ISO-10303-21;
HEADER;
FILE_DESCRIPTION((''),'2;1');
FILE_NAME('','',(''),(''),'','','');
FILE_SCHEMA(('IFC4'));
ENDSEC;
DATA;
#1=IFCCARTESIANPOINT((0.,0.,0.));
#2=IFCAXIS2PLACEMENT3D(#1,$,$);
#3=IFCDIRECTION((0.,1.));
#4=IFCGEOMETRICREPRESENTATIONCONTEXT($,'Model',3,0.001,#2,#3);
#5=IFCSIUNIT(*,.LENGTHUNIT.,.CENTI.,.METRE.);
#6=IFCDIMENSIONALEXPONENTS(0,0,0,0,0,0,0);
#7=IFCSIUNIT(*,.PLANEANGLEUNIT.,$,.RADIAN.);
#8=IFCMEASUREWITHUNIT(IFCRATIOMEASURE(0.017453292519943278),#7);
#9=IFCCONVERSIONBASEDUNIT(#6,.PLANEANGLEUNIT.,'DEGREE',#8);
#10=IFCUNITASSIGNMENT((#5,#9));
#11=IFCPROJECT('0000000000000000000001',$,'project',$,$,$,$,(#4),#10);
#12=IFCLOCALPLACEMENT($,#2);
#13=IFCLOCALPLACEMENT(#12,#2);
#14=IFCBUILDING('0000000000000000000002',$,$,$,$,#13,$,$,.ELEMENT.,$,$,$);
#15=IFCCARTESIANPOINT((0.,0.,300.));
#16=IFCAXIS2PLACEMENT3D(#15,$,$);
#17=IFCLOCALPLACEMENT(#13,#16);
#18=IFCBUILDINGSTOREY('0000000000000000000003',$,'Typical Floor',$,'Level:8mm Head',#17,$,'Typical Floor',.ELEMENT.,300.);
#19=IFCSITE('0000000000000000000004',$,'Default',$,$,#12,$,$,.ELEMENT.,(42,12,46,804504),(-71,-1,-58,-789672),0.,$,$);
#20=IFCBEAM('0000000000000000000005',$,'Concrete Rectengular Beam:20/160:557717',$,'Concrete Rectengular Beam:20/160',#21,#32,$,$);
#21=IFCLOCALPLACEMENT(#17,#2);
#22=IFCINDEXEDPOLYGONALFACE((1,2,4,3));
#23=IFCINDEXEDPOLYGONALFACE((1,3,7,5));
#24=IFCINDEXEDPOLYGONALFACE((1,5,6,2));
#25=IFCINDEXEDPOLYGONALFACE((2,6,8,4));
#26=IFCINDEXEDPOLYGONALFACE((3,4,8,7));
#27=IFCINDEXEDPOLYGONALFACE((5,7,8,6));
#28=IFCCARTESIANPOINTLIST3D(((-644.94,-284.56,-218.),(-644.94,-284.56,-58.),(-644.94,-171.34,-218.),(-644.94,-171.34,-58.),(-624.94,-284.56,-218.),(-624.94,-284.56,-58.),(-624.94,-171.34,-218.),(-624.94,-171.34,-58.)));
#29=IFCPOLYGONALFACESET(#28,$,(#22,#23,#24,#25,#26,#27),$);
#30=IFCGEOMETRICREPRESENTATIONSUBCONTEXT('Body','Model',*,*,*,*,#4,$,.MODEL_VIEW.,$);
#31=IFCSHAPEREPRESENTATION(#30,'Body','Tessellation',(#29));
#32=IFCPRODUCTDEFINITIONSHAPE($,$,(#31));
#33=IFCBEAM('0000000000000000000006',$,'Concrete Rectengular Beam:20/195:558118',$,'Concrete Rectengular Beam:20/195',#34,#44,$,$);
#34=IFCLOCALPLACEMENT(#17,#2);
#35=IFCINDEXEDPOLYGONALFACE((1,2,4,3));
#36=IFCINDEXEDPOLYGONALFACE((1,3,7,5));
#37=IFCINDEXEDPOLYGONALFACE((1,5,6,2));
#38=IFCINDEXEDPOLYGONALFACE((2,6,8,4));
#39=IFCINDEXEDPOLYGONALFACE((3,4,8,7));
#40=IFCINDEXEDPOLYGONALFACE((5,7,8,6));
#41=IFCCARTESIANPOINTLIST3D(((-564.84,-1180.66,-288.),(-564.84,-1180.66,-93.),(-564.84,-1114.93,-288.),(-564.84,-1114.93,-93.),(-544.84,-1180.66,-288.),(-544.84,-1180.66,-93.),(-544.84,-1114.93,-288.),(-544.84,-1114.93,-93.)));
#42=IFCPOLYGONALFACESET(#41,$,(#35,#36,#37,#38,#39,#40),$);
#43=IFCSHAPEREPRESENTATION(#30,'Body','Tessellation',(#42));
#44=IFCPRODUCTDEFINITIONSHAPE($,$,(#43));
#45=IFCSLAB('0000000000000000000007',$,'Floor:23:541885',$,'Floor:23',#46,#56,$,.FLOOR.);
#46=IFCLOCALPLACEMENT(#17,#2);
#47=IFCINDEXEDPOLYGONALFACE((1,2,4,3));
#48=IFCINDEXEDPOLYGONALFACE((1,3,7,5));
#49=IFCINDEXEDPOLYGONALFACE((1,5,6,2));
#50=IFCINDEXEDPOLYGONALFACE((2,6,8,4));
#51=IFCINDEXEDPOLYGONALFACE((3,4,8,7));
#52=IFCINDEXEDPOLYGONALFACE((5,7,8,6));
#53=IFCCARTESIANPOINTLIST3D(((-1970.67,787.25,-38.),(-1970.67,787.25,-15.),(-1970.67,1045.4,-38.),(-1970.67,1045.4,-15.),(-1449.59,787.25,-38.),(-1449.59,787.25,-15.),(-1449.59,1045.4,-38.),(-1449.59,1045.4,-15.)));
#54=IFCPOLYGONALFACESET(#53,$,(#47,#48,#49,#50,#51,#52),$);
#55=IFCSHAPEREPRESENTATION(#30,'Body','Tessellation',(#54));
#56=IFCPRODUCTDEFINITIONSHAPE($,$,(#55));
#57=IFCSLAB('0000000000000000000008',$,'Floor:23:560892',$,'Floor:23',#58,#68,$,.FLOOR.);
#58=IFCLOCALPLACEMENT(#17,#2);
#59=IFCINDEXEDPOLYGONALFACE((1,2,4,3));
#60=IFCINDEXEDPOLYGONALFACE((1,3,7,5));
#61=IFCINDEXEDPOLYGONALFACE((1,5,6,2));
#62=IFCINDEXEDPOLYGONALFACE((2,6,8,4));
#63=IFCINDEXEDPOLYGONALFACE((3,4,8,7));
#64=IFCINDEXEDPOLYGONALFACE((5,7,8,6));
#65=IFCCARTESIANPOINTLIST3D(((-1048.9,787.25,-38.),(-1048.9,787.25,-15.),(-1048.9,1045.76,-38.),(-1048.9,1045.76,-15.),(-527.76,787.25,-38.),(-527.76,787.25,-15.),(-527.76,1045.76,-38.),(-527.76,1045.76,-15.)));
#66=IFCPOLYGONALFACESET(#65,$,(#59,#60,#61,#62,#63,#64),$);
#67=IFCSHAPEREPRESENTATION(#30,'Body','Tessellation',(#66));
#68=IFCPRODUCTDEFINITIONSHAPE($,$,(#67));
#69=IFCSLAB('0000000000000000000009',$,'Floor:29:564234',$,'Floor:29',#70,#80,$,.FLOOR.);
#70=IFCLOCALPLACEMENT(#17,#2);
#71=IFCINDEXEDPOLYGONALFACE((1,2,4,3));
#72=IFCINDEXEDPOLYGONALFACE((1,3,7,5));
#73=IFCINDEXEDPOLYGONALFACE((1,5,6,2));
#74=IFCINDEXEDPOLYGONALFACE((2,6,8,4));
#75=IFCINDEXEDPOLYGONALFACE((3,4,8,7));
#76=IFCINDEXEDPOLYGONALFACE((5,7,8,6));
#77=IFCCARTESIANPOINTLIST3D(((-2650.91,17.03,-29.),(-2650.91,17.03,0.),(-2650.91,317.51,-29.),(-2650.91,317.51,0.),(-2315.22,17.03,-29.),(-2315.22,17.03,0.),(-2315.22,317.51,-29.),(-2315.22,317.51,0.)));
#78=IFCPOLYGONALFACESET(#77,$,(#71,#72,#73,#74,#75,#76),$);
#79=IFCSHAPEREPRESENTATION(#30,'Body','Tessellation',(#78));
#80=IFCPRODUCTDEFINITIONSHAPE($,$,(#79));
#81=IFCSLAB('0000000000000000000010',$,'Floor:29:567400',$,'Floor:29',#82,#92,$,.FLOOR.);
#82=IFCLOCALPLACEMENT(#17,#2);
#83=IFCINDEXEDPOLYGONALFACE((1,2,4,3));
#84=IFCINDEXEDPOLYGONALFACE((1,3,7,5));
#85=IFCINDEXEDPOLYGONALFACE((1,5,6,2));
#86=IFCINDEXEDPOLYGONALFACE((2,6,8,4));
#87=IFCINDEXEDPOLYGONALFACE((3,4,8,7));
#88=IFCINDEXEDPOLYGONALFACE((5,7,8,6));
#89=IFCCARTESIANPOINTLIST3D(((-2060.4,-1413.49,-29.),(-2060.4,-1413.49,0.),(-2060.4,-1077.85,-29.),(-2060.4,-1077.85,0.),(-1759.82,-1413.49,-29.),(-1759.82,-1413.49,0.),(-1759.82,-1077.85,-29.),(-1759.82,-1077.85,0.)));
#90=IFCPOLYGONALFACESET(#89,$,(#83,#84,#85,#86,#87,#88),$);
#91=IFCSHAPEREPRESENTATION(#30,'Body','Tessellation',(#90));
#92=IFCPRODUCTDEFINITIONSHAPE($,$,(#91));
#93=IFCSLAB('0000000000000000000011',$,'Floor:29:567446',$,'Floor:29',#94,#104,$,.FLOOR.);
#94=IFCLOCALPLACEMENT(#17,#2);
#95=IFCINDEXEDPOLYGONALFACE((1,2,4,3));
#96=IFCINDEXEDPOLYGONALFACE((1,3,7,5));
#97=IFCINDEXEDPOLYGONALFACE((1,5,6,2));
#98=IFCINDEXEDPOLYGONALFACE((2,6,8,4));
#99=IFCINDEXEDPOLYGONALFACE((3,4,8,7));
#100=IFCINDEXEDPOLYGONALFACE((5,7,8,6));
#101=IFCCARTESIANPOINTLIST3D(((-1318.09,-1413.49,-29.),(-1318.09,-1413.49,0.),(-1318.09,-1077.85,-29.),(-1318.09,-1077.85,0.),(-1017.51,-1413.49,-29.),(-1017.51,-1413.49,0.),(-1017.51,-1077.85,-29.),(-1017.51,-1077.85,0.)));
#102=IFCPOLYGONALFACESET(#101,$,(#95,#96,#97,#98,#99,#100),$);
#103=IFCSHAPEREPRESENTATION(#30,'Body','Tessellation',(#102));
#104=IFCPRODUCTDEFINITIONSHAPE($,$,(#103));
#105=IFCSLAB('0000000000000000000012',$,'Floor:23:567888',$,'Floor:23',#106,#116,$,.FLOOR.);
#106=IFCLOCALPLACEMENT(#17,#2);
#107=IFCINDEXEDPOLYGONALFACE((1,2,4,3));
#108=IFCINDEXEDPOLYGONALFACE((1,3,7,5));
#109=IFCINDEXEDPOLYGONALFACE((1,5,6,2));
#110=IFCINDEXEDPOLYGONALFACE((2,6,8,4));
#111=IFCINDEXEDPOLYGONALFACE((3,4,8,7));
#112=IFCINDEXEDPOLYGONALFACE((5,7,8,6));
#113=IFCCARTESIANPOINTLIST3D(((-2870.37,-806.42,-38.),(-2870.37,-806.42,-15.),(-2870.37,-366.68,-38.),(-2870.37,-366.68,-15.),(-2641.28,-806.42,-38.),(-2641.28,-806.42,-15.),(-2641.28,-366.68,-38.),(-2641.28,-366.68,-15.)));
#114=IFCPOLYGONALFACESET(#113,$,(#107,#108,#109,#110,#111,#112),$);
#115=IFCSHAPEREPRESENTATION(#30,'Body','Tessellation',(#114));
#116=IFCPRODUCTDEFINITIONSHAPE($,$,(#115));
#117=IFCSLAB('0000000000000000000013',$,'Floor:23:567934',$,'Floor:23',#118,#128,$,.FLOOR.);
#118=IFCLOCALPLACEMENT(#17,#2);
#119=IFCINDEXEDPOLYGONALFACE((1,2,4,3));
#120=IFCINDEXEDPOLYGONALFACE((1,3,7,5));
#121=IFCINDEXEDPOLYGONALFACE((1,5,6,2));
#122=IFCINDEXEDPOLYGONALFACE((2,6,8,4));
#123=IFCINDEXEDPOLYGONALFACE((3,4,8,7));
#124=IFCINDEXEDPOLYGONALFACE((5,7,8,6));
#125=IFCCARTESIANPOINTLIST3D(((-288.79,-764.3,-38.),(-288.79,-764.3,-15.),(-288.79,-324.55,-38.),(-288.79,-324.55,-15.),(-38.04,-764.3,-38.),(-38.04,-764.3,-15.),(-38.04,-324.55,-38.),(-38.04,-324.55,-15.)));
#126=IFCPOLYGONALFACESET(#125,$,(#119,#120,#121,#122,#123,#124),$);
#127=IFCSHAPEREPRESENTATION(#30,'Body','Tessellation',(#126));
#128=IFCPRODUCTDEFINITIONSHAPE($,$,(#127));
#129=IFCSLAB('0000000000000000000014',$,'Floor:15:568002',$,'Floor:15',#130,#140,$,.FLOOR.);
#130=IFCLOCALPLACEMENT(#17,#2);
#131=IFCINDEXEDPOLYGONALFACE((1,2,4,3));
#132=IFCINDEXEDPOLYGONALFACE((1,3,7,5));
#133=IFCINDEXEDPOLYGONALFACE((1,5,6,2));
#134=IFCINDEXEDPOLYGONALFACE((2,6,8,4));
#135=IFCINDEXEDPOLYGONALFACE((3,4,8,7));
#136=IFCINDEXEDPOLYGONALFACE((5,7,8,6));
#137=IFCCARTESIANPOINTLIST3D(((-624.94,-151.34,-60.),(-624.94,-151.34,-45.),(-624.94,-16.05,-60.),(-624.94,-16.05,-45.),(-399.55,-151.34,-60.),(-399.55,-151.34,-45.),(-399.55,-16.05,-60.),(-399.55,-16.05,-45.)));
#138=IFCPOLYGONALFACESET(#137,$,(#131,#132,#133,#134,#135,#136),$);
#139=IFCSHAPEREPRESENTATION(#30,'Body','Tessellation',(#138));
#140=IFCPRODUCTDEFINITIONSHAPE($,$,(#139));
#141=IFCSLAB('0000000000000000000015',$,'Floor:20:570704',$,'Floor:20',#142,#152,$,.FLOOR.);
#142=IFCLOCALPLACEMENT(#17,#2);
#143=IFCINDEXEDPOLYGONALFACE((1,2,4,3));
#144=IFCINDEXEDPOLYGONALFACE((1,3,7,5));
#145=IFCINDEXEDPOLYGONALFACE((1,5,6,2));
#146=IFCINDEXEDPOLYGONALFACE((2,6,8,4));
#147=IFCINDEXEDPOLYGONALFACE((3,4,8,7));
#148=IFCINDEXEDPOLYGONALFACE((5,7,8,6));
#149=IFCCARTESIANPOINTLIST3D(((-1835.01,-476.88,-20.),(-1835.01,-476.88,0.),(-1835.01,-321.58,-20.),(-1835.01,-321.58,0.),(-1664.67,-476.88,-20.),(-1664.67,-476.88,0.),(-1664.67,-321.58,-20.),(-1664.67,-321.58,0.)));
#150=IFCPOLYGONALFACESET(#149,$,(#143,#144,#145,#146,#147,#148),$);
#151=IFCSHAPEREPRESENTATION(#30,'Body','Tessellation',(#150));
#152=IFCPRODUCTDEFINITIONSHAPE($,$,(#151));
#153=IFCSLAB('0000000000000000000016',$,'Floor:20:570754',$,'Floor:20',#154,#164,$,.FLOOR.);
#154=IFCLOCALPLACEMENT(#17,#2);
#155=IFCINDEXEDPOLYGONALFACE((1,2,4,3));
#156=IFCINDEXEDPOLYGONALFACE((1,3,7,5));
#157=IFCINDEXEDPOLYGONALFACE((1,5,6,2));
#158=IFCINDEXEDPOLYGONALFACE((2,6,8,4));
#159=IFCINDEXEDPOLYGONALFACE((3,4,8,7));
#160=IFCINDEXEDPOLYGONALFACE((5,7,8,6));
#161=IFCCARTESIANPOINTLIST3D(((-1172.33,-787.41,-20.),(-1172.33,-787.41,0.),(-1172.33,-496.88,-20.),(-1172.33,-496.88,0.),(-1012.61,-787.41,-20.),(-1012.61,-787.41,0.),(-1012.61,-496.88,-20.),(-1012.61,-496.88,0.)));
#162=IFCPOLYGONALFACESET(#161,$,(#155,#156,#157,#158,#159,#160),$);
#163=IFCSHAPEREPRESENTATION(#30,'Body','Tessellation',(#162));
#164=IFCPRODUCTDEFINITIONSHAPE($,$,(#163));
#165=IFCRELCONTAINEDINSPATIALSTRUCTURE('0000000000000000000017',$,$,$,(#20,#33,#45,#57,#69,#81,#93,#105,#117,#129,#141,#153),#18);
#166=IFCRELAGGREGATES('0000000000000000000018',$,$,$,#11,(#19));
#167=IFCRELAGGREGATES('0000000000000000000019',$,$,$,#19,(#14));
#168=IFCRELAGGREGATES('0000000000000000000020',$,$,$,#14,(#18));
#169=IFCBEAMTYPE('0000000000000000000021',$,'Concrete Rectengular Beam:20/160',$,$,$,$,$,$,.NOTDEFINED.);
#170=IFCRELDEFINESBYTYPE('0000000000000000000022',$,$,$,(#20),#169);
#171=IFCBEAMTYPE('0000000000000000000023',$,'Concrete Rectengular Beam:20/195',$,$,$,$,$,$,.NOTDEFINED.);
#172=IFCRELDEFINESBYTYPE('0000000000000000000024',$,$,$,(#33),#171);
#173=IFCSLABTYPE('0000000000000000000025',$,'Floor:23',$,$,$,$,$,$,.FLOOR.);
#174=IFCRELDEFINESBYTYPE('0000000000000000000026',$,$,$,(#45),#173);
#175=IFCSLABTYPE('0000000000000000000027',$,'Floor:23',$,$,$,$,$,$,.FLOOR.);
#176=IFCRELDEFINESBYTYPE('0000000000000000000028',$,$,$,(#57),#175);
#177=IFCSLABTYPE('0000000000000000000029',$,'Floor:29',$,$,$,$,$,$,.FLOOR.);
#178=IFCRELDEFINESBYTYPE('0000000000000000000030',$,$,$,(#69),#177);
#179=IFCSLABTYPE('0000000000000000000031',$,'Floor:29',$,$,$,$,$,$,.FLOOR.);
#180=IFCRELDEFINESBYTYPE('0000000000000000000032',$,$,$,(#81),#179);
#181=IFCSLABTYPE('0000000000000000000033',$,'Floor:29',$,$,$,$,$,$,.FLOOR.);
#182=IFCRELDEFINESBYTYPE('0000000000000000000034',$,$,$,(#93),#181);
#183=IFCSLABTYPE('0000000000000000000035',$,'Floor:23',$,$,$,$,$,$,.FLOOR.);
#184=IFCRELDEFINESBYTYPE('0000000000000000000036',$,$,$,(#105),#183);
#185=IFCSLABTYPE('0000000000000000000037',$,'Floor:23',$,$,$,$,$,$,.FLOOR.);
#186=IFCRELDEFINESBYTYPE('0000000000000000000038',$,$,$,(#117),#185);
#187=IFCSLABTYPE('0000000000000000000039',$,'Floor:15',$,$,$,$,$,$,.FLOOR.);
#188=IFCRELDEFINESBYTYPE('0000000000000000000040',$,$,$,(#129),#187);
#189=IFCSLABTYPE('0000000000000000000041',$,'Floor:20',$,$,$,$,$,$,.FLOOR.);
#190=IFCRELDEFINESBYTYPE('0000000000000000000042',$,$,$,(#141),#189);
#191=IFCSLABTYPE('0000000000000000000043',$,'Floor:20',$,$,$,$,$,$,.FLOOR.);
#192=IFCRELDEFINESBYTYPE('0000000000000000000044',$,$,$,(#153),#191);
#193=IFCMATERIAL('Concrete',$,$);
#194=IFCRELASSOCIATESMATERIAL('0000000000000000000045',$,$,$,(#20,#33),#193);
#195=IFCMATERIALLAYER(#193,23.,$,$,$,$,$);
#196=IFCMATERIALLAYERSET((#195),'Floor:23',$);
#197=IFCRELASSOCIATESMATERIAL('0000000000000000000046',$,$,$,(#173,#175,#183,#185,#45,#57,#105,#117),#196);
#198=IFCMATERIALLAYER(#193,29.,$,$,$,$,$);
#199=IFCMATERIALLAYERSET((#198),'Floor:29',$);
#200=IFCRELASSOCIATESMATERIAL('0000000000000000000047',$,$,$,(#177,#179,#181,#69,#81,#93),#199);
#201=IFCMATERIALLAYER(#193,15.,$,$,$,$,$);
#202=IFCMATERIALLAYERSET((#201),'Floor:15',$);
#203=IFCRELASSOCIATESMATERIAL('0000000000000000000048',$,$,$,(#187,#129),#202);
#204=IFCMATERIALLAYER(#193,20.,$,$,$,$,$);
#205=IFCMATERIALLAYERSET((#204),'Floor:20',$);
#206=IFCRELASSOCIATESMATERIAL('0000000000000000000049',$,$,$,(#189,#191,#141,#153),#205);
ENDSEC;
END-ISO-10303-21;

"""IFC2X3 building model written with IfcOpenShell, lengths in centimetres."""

from ifc_helpers import new_model, entity, si_unit, converted_unit, direction, frame, frame_2d, origin, origin_2d_with_axis, place, context, subcontext, project, spatial, rectangle, extrude, material, layer, layer_set, layer_usage, type_object, element, save


model = new_model("IFC2X3")

# Units and contexts
model_context = context("Model", 3, precision=0.001, world=origin(), true_north=direction((0.0, 1.0)))
body_context = subcontext(model_context, "Body", "Model", "MODEL_VIEW")
ifc_project = project(units=[si_unit("LENGTHUNIT", "METRE", prefix="CENTI"), converted_unit("PLANEANGLEUNIT", "DEGREE", entity("IfcRatioMeasure", 0.017453292519943278), si_unit("PLANEANGLEUNIT", "RADIAN"), dimensions=[0, 0, 0, 0, 0, 0, 0])], contexts=[model_context])

# Site, building, storey
site_placement = place(None, origin())
site = spatial("IfcSite", under=ifc_project, at=site_placement, Name="Default", CompositionType="ELEMENT", RefLatitude=(42, 12, 46, 804504), RefLongitude=(-71, -1, -58, -789672), RefElevation=0.0)
building_placement = place(site_placement, origin())
building = spatial("IfcBuilding", under=site, at=building_placement, CompositionType="ELEMENT")
storey_placement = place(building_placement, frame((0.0, 0.0, 300.0)))
storey = spatial("IfcBuildingStorey", under=building, at=storey_placement, Name="Typical Floor", ObjectType="Level:8mm Head", LongName="Typical Floor", CompositionType="ELEMENT", Elevation=300.0)

# Beams
ifc_material = material(Name="Concrete")
beam_type_1 = type_object("IfcBeamType", Name="Concrete Rectengular Beam:20/160", PredefinedType="NOTDEFINED")
beam_1_placement = place(storey_placement, frame((-634.94, -304.55, 0.0), z_axis=(0.0, 0.0, 1.0), x_axis=(0.0, 1.0, 0.0)))
element("IfcBeam", 1, at=beam_1_placement, inside=storey, type_object=beam_type_1, material=ifc_material, Name="Concrete Rectengular Beam:20/160:557717", ObjectType="Concrete Rectengular Beam:20/160", context=body_context, shape_type="SweptSolid", body=[
    extrude(rectangle(XDim=160.0, YDim=20.0, at=frame_2d((0.0, 0.0), x_axis=(1.0, 0.0))), frame((20.0, 0.0, -138.0), z_axis=(1.0, 0.0, 0.0), x_axis=(0.0, 0.0, -1.0)), (0.0, 0.0, 1.0), 113.22),
])
beam_type_2 = type_object("IfcBeamType", Name="Concrete Rectengular Beam:20/195", PredefinedType="NOTDEFINED")
beam_2_placement = place(storey_placement, frame((-554.84, -1190.66, 0.0), z_axis=(0.0, 0.0, 1.0), x_axis=(0.0, 1.0, 0.0)))
element("IfcBeam", 2, at=beam_2_placement, inside=storey, type_object=beam_type_2, material=ifc_material, Name="Concrete Rectengular Beam:20/195:558118", ObjectType="Concrete Rectengular Beam:20/195", context=body_context, shape_type="SweptSolid", body=[
    extrude(rectangle(XDim=195.0, YDim=20.0, at=frame_2d((0.0, 0.0), x_axis=(1.0, 0.0))), frame((10.0, 0.0, -190.5), z_axis=(1.0, 0.0, 0.0), x_axis=(0.0, 0.0, -1.0)), (0.0, 0.0, 1.0), 65.73),
])

# Slabs
ifc_layer_1 = layer(ifc_material, 23.0)
ifc_layer_set_1 = layer_set([ifc_layer_1], Name="Floor:23")
ifc_layer_usage_1 = layer_usage(ifc_layer_set_1, "AXIS3", "POSITIVE", 0.0)
slab_type_1 = type_object("IfcSlabType", Name="Floor:23", PredefinedType="FLOOR", material=ifc_layer_set_1)
slab_1_placement = place(storey_placement, origin())
element("IfcSlab", 3, at=slab_1_placement, inside=storey, type_object=slab_type_1, material=ifc_layer_usage_1, Name="Floor:23:541885", ObjectType="Floor:23", PredefinedType="FLOOR", context=body_context, shape_type="SweptSolid", body=[
    extrude(rectangle(XDim=258.15, YDim=521.09, at=frame_2d((0.0, 0.0), x_axis=(1.0, 0.0))), frame((-1710.13, 916.32, -15.0), z_axis=(0.0, 0.0, -1.0), x_axis=(0.0, 1.0, 0.0)), (0.0, 0.0, 1.0), 23.0),
])
ifc_layer_usage_2 = layer_usage(ifc_layer_set_1, "AXIS3", "POSITIVE", 0.0)
slab_type_2 = type_object("IfcSlabType", Name="Floor:23", PredefinedType="FLOOR", material=ifc_layer_set_1)
slab_2_placement = place(storey_placement, origin())
element("IfcSlab", 4, at=slab_2_placement, inside=storey, type_object=slab_type_2, material=ifc_layer_usage_2, Name="Floor:23:560892", ObjectType="Floor:23", PredefinedType="FLOOR", context=body_context, shape_type="SweptSolid", body=[
    extrude(rectangle(XDim=258.51, YDim=521.14, at=origin_2d_with_axis()), frame((-788.33, 916.51, -15.0), z_axis=(0.0, 0.0, -1.0), x_axis=(0.0, 1.0, 0.0)), (0.0, 0.0, 1.0), 23.0),
])
ifc_layer_2 = layer(ifc_material, 20.0)
ifc_layer_set_2 = layer_set([ifc_layer_2], Name="Floor:20")
ifc_layer_3 = layer(ifc_material, 29.0)
ifc_layer_set_3 = layer_set([ifc_layer_3], Name="Floor:29")
ifc_layer_usage_3 = layer_usage(ifc_layer_set_3, "AXIS3", "POSITIVE", 0.0)
slab_type_3 = type_object("IfcSlabType", Name="Floor:29", PredefinedType="FLOOR", material=ifc_layer_set_3)
slab_3_placement = place(storey_placement, origin())
element("IfcSlab", 5, at=slab_3_placement, inside=storey, type_object=slab_type_3, material=ifc_layer_usage_3, Name="Floor:29:564234", ObjectType="Floor:29", PredefinedType="FLOOR", context=body_context, shape_type="SweptSolid", body=[
    extrude(rectangle(XDim=300.48, YDim=335.68, at=frame_2d((0.0, 0.0), x_axis=(1.0, 0.0))), frame((-2483.06, 167.27, 0.0), z_axis=(0.0, 0.0, -1.0), x_axis=(0.0, 1.0, 0.0)), (0.0, 0.0, 1.0), 29.0),
])
ifc_layer_usage_4 = layer_usage(ifc_layer_set_3, "AXIS3", "POSITIVE", 0.0)
slab_type_4 = type_object("IfcSlabType", Name="Floor:29", PredefinedType="FLOOR", material=ifc_layer_set_3)
slab_4_placement = place(storey_placement, origin())
element("IfcSlab", 6, at=slab_4_placement, inside=storey, type_object=slab_type_4, material=ifc_layer_usage_4, Name="Floor:29:567400", ObjectType="Floor:29", PredefinedType="FLOOR", context=body_context, shape_type="SweptSolid", body=[
    extrude(rectangle(XDim=335.63, YDim=300.59, at=frame_2d((0.0, 0.0), x_axis=(1.0, 0.0))), frame((-1910.11, -1245.67, 0.0), z_axis=(0.0, 0.0, -1.0), x_axis=(0.0, 1.0, 0.0)), (0.0, 0.0, 1.0), 29.0),
])
ifc_layer_usage_5 = layer_usage(ifc_layer_set_3, "AXIS3", "POSITIVE", 0.0)
slab_type_5 = type_object("IfcSlabType", Name="Floor:29", PredefinedType="FLOOR", material=ifc_layer_set_3)
slab_5_placement = place(storey_placement, origin())
element("IfcSlab", 7, at=slab_5_placement, inside=storey, type_object=slab_type_5, material=ifc_layer_usage_5, Name="Floor:29:567446", ObjectType="Floor:29", PredefinedType="FLOOR", context=body_context, shape_type="SweptSolid", body=[
    extrude(rectangle(XDim=335.63, YDim=300.59, at=frame_2d((0.0, 0.0), x_axis=(1.0, 0.0))), frame((-1167.8, -1245.67, 0.0), z_axis=(0.0, 0.0, -1.0), x_axis=(0.0, 1.0, 0.0)), (0.0, 0.0, 1.0), 29.0),
])
ifc_layer_usage_6 = layer_usage(ifc_layer_set_1, "AXIS3", "POSITIVE", 0.0)
slab_type_6 = type_object("IfcSlabType", Name="Floor:23", PredefinedType="FLOOR", material=ifc_layer_set_1)
slab_6_placement = place(storey_placement, origin())
element("IfcSlab", 8, at=slab_6_placement, inside=storey, type_object=slab_type_6, material=ifc_layer_usage_6, Name="Floor:23:567888", ObjectType="Floor:23", PredefinedType="FLOOR", context=body_context, shape_type="SweptSolid", body=[
    extrude(rectangle(XDim=439.74, YDim=229.09, at=frame_2d((0.0, 0.0), x_axis=(1.0, 0.0))), frame((-2755.82, -586.55, -15.0), z_axis=(0.0, 0.0, -1.0), x_axis=(0.0, 1.0, 0.0)), (0.0, 0.0, 1.0), 23.0),
])
ifc_layer_usage_7 = layer_usage(ifc_layer_set_1, "AXIS3", "POSITIVE", 0.0)
slab_type_7 = type_object("IfcSlabType", Name="Floor:23", PredefinedType="FLOOR", material=ifc_layer_set_1)
slab_7_placement = place(storey_placement, origin())
element("IfcSlab", 9, at=slab_7_placement, inside=storey, type_object=slab_type_7, material=ifc_layer_usage_7, Name="Floor:23:567934", ObjectType="Floor:23", PredefinedType="FLOOR", context=body_context, shape_type="SweptSolid", body=[
    extrude(rectangle(XDim=439.75, YDim=250.76, at=frame_2d((0.0, 0.0), x_axis=(1.0, 0.0))), frame((-163.41, -544.43, -15.0), z_axis=(0.0, 0.0, -1.0), x_axis=(0.0, 1.0, 0.0)), (0.0, 0.0, 1.0), 23.0),
])
ifc_layer_4 = layer(ifc_material, 15.0)
ifc_layer_set_4 = layer_set([ifc_layer_4], Name="Floor:15")
ifc_layer_usage_8 = layer_usage(ifc_layer_set_4, "AXIS3", "POSITIVE", 0.0)
slab_type_8 = type_object("IfcSlabType", Name="Floor:15", PredefinedType="FLOOR", material=ifc_layer_set_4)
slab_8_placement = place(storey_placement, origin())
element("IfcSlab", 10, at=slab_8_placement, inside=storey, type_object=slab_type_8, material=ifc_layer_usage_8, Name="Floor:15:568002", ObjectType="Floor:15", PredefinedType="FLOOR", context=body_context, shape_type="SweptSolid", body=[
    extrude(rectangle(XDim=135.29, YDim=225.39, at=frame_2d((0.0, 0.0), x_axis=(1.0, 0.0))), frame((-512.24, -83.69, -45.0), z_axis=(0.0, 0.0, -1.0), x_axis=(0.0, 1.0, 0.0)), (0.0, 0.0, 1.0), 15.0),
])
ifc_layer_usage_9 = layer_usage(ifc_layer_set_2, "AXIS3", "POSITIVE", 0.0)
slab_type_9 = type_object("IfcSlabType", Name="Floor:20", PredefinedType="FLOOR", material=ifc_layer_set_2)
slab_9_placement = place(storey_placement, origin())
element("IfcSlab", 11, at=slab_9_placement, inside=storey, type_object=slab_type_9, material=ifc_layer_usage_9, Name="Floor:20:570704", ObjectType="Floor:20", PredefinedType="FLOOR", context=body_context, shape_type="SweptSolid", body=[
    extrude(rectangle(XDim=155.29, YDim=170.34, at=frame_2d((0.0, 0.0), x_axis=(1.0, 0.0))), frame((-1749.84, -399.23, 0.0), z_axis=(0.0, 0.0, -1.0), x_axis=(0.0, 1.0, 0.0)), (0.0, 0.0, 1.0), 20.0),
])
ifc_layer_usage_10 = layer_usage(ifc_layer_set_2, "AXIS3", "POSITIVE", 0.0)
slab_type_10 = type_object("IfcSlabType", Name="Floor:20", PredefinedType="FLOOR", material=ifc_layer_set_2)
slab_10_placement = place(storey_placement, origin())
element("IfcSlab", 12, at=slab_10_placement, inside=storey, type_object=slab_type_10, material=ifc_layer_usage_10, Name="Floor:20:570754", ObjectType="Floor:20", PredefinedType="FLOOR", context=body_context, shape_type="SweptSolid", body=[
    extrude(rectangle(XDim=159.72, YDim=290.53, at=frame_2d((0.0, 0.0), x_axis=(1.0, 0.0))), frame((-1092.47, -642.14, 0.0), z_axis=(0.0, 0.0, -1.0), x_axis=(1.0, 0.0, 0.0)), (0.0, 0.0, 1.0), 20.0),
])

save(model, "model.ifc")
